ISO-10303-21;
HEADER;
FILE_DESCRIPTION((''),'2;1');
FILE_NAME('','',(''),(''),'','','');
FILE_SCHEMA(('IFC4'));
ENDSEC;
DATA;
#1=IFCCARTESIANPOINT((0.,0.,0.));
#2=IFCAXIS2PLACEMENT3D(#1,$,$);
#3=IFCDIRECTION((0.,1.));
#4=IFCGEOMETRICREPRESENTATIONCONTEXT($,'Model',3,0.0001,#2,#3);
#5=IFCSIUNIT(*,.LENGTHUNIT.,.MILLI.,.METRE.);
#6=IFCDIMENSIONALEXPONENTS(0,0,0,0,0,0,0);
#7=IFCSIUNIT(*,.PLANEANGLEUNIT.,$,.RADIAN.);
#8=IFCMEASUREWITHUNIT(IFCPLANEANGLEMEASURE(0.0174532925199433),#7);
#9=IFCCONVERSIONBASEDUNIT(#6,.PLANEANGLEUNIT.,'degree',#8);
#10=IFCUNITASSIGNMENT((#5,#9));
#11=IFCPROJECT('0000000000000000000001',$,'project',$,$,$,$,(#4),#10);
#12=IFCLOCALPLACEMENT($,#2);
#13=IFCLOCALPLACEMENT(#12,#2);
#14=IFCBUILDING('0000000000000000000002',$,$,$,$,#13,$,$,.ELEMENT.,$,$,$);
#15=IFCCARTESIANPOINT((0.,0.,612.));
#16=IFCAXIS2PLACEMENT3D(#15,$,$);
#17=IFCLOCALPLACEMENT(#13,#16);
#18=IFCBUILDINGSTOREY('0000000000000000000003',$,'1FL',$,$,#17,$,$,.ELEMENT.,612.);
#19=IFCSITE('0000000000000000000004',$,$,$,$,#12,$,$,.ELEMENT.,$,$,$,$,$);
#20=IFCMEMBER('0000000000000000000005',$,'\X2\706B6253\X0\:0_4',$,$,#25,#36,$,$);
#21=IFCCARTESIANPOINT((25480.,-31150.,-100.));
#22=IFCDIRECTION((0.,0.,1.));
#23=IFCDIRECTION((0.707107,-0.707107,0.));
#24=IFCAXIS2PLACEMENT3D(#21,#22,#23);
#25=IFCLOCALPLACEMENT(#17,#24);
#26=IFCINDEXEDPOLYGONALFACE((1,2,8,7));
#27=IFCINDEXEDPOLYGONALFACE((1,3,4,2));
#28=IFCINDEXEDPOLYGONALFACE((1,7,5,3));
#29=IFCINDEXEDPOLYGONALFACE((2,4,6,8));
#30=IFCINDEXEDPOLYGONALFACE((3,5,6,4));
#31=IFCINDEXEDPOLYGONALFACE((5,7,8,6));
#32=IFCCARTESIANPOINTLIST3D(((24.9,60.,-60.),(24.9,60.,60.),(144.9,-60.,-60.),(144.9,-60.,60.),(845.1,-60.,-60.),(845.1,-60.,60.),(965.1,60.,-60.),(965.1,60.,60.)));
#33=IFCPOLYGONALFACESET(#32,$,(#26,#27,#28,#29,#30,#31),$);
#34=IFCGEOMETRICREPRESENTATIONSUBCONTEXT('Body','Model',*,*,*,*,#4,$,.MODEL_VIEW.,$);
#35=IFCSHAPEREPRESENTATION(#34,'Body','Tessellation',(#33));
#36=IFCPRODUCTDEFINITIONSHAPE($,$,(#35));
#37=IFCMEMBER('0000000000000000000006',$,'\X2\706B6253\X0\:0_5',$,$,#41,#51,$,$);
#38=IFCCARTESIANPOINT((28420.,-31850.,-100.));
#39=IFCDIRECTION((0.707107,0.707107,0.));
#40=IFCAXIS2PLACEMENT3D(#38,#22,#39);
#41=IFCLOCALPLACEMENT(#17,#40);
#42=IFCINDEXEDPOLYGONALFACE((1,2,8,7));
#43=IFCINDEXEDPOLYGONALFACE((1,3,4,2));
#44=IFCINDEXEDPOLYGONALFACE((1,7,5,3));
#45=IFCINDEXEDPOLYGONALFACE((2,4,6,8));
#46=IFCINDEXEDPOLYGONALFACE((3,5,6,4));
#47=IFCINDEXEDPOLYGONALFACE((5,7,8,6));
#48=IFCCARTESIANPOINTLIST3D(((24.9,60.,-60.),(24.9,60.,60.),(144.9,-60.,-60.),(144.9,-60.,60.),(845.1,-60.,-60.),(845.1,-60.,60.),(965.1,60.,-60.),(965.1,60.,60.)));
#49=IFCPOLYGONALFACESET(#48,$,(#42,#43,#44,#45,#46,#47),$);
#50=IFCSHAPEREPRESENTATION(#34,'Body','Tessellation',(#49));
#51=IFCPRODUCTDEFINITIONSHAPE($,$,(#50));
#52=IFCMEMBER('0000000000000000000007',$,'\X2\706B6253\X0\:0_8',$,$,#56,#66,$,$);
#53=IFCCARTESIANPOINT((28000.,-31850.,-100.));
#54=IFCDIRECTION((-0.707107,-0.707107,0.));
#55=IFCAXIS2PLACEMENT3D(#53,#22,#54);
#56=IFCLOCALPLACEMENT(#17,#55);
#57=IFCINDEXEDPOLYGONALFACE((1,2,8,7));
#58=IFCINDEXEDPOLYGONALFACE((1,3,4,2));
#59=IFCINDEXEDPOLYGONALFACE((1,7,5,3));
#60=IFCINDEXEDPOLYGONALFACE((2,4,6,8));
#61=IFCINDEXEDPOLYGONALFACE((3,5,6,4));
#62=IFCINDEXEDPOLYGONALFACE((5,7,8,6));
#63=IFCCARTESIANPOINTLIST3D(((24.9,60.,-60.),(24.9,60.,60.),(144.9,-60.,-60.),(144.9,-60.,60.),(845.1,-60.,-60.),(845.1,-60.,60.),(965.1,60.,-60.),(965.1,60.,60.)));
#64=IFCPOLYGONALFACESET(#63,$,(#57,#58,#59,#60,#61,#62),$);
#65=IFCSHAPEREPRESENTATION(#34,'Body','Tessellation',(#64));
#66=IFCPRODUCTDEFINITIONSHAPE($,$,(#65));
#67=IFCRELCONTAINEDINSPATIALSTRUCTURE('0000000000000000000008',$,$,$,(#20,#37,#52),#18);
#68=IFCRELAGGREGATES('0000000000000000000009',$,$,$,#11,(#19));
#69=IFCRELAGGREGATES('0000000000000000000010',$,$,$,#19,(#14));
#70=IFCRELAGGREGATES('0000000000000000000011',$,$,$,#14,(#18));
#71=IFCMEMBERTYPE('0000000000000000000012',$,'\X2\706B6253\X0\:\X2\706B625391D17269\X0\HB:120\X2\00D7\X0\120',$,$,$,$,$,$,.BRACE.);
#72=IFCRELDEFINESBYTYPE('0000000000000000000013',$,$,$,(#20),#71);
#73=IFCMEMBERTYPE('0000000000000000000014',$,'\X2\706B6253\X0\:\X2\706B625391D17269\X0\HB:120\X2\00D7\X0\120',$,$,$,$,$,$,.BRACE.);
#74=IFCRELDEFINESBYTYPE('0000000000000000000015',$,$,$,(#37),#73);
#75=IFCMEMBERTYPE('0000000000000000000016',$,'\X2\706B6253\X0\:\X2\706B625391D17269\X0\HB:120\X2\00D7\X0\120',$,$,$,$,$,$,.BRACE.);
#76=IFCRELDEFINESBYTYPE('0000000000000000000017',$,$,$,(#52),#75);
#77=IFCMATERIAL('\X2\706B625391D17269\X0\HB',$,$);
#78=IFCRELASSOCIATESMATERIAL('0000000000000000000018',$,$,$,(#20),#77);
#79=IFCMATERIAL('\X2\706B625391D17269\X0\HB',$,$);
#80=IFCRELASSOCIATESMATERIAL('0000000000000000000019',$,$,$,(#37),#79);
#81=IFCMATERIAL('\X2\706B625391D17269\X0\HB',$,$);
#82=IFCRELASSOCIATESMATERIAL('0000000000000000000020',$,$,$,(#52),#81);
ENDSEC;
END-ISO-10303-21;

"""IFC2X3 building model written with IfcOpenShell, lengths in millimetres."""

from ifc_helpers import new_model, entity, si_unit, converted_unit, direction, frame, origin, place, context, subcontext, project, spatial, polyline, outline, extrude, material, type_object, element, save


model = new_model("IFC2X3")

# Units and contexts
model_context = context("Model", 3, precision=0.0001, world=origin(), true_north=direction((0.0, 1.0)))
body_context = subcontext(model_context, "Body", "Model", "MODEL_VIEW")
ifc_project = project(units=[si_unit("LENGTHUNIT", "METRE", prefix="MILLI"), converted_unit("PLANEANGLEUNIT", "degree", entity("IfcPlaneAngleMeasure", 0.0174532925199433), si_unit("PLANEANGLEUNIT", "RADIAN"), dimensions=[0, 0, 0, 0, 0, 0, 0])], contexts=[model_context])

# Site, building, storey
site_placement = place(None, origin())
site = spatial("IfcSite", under=ifc_project, at=site_placement, CompositionType="ELEMENT")
building_placement = place(site_placement, origin())
building = spatial("IfcBuilding", under=site, at=building_placement, CompositionType="ELEMENT")
storey_placement = place(building_placement, frame((0.0, 0.0, 612.0)))
storey = spatial("IfcBuildingStorey", under=building, at=storey_placement, Name="1FL", CompositionType="ELEMENT", Elevation=612.0)

# Members
ifc_material_1 = material(Name="火打金物HB")
member_type_1 = type_object("IfcMemberType", Name="火打:火打金物HB:120×120", PredefinedType="BRACE")
member_1_placement = place(storey_placement, frame((25480.0, -31150.0, -100.0), z_axis=(0.0, 0.0, 1.0), x_axis=(0.707107, -0.707107, 0.0)))
element("IfcMember", 1, at=member_1_placement, inside=storey, type_object=member_type_1, material=ifc_material_1, Name="火打:0_4", context=body_context, shape_type="SweptSolid", body=[
    extrude(outline(polyline([(144.9, -60.0, 0.0), (24.9, 60.0, 0.0), (965.1, 60.0, 0.0), (845.1, -60.0, 0.0), (144.9, -60.0, 0.0)])), frame((0.0, 0.0, -60.0), z_axis=(0.0, 0.0, 1.0), x_axis=(1.0, 0.0, 0.0)), (0.0, 0.0, 1.0), 120.0),
])
ifc_material_2 = material(Name="火打金物HB")
member_type_2 = type_object("IfcMemberType", Name="火打:火打金物HB:120×120", PredefinedType="BRACE")
member_2_placement = place(storey_placement, frame((28420.0, -31850.0, -100.0), z_axis=(0.0, 0.0, 1.0), x_axis=(0.707107, 0.707107, 0.0)))
element("IfcMember", 2, at=member_2_placement, inside=storey, type_object=member_type_2, material=ifc_material_2, Name="火打:0_5", context=body_context, shape_type="SweptSolid", body=[
    extrude(outline(polyline([(144.9, -60.0, 0.0), (24.9, 60.0, 0.0), (965.1, 60.0, 0.0), (845.1, -60.0, 0.0), (144.9, -60.0, 0.0)])), frame((0.0, 0.0, -60.0), z_axis=(0.0, 0.0, 1.0), x_axis=(1.0, 0.0, 0.0)), (0.0, 0.0, 1.0), 120.0),
])
ifc_material_3 = material(Name="火打金物HB")
member_type_3 = type_object("IfcMemberType", Name="火打:火打金物HB:120×120", PredefinedType="BRACE")
member_3_placement = place(storey_placement, frame((28000.0, -31850.0, -100.0), z_axis=(0.0, 0.0, 1.0), x_axis=(-0.707107, -0.707107, 0.0)))
element("IfcMember", 3, at=member_3_placement, inside=storey, type_object=member_type_3, material=ifc_material_3, Name="火打:0_8", context=body_context, shape_type="SweptSolid", body=[
    extrude(outline(polyline([(144.9, -60.0, 0.0), (24.9, 60.0, 0.0), (965.1, 60.0, 0.0), (845.1, -60.0, 0.0), (144.9, -60.0, 0.0)])), frame((0.0, 0.0, -60.0), z_axis=(0.0, 0.0, 1.0), x_axis=(1.0, 0.0, 0.0)), (0.0, 0.0, 1.0), 120.0),
])

save(model, "model.ifc")
